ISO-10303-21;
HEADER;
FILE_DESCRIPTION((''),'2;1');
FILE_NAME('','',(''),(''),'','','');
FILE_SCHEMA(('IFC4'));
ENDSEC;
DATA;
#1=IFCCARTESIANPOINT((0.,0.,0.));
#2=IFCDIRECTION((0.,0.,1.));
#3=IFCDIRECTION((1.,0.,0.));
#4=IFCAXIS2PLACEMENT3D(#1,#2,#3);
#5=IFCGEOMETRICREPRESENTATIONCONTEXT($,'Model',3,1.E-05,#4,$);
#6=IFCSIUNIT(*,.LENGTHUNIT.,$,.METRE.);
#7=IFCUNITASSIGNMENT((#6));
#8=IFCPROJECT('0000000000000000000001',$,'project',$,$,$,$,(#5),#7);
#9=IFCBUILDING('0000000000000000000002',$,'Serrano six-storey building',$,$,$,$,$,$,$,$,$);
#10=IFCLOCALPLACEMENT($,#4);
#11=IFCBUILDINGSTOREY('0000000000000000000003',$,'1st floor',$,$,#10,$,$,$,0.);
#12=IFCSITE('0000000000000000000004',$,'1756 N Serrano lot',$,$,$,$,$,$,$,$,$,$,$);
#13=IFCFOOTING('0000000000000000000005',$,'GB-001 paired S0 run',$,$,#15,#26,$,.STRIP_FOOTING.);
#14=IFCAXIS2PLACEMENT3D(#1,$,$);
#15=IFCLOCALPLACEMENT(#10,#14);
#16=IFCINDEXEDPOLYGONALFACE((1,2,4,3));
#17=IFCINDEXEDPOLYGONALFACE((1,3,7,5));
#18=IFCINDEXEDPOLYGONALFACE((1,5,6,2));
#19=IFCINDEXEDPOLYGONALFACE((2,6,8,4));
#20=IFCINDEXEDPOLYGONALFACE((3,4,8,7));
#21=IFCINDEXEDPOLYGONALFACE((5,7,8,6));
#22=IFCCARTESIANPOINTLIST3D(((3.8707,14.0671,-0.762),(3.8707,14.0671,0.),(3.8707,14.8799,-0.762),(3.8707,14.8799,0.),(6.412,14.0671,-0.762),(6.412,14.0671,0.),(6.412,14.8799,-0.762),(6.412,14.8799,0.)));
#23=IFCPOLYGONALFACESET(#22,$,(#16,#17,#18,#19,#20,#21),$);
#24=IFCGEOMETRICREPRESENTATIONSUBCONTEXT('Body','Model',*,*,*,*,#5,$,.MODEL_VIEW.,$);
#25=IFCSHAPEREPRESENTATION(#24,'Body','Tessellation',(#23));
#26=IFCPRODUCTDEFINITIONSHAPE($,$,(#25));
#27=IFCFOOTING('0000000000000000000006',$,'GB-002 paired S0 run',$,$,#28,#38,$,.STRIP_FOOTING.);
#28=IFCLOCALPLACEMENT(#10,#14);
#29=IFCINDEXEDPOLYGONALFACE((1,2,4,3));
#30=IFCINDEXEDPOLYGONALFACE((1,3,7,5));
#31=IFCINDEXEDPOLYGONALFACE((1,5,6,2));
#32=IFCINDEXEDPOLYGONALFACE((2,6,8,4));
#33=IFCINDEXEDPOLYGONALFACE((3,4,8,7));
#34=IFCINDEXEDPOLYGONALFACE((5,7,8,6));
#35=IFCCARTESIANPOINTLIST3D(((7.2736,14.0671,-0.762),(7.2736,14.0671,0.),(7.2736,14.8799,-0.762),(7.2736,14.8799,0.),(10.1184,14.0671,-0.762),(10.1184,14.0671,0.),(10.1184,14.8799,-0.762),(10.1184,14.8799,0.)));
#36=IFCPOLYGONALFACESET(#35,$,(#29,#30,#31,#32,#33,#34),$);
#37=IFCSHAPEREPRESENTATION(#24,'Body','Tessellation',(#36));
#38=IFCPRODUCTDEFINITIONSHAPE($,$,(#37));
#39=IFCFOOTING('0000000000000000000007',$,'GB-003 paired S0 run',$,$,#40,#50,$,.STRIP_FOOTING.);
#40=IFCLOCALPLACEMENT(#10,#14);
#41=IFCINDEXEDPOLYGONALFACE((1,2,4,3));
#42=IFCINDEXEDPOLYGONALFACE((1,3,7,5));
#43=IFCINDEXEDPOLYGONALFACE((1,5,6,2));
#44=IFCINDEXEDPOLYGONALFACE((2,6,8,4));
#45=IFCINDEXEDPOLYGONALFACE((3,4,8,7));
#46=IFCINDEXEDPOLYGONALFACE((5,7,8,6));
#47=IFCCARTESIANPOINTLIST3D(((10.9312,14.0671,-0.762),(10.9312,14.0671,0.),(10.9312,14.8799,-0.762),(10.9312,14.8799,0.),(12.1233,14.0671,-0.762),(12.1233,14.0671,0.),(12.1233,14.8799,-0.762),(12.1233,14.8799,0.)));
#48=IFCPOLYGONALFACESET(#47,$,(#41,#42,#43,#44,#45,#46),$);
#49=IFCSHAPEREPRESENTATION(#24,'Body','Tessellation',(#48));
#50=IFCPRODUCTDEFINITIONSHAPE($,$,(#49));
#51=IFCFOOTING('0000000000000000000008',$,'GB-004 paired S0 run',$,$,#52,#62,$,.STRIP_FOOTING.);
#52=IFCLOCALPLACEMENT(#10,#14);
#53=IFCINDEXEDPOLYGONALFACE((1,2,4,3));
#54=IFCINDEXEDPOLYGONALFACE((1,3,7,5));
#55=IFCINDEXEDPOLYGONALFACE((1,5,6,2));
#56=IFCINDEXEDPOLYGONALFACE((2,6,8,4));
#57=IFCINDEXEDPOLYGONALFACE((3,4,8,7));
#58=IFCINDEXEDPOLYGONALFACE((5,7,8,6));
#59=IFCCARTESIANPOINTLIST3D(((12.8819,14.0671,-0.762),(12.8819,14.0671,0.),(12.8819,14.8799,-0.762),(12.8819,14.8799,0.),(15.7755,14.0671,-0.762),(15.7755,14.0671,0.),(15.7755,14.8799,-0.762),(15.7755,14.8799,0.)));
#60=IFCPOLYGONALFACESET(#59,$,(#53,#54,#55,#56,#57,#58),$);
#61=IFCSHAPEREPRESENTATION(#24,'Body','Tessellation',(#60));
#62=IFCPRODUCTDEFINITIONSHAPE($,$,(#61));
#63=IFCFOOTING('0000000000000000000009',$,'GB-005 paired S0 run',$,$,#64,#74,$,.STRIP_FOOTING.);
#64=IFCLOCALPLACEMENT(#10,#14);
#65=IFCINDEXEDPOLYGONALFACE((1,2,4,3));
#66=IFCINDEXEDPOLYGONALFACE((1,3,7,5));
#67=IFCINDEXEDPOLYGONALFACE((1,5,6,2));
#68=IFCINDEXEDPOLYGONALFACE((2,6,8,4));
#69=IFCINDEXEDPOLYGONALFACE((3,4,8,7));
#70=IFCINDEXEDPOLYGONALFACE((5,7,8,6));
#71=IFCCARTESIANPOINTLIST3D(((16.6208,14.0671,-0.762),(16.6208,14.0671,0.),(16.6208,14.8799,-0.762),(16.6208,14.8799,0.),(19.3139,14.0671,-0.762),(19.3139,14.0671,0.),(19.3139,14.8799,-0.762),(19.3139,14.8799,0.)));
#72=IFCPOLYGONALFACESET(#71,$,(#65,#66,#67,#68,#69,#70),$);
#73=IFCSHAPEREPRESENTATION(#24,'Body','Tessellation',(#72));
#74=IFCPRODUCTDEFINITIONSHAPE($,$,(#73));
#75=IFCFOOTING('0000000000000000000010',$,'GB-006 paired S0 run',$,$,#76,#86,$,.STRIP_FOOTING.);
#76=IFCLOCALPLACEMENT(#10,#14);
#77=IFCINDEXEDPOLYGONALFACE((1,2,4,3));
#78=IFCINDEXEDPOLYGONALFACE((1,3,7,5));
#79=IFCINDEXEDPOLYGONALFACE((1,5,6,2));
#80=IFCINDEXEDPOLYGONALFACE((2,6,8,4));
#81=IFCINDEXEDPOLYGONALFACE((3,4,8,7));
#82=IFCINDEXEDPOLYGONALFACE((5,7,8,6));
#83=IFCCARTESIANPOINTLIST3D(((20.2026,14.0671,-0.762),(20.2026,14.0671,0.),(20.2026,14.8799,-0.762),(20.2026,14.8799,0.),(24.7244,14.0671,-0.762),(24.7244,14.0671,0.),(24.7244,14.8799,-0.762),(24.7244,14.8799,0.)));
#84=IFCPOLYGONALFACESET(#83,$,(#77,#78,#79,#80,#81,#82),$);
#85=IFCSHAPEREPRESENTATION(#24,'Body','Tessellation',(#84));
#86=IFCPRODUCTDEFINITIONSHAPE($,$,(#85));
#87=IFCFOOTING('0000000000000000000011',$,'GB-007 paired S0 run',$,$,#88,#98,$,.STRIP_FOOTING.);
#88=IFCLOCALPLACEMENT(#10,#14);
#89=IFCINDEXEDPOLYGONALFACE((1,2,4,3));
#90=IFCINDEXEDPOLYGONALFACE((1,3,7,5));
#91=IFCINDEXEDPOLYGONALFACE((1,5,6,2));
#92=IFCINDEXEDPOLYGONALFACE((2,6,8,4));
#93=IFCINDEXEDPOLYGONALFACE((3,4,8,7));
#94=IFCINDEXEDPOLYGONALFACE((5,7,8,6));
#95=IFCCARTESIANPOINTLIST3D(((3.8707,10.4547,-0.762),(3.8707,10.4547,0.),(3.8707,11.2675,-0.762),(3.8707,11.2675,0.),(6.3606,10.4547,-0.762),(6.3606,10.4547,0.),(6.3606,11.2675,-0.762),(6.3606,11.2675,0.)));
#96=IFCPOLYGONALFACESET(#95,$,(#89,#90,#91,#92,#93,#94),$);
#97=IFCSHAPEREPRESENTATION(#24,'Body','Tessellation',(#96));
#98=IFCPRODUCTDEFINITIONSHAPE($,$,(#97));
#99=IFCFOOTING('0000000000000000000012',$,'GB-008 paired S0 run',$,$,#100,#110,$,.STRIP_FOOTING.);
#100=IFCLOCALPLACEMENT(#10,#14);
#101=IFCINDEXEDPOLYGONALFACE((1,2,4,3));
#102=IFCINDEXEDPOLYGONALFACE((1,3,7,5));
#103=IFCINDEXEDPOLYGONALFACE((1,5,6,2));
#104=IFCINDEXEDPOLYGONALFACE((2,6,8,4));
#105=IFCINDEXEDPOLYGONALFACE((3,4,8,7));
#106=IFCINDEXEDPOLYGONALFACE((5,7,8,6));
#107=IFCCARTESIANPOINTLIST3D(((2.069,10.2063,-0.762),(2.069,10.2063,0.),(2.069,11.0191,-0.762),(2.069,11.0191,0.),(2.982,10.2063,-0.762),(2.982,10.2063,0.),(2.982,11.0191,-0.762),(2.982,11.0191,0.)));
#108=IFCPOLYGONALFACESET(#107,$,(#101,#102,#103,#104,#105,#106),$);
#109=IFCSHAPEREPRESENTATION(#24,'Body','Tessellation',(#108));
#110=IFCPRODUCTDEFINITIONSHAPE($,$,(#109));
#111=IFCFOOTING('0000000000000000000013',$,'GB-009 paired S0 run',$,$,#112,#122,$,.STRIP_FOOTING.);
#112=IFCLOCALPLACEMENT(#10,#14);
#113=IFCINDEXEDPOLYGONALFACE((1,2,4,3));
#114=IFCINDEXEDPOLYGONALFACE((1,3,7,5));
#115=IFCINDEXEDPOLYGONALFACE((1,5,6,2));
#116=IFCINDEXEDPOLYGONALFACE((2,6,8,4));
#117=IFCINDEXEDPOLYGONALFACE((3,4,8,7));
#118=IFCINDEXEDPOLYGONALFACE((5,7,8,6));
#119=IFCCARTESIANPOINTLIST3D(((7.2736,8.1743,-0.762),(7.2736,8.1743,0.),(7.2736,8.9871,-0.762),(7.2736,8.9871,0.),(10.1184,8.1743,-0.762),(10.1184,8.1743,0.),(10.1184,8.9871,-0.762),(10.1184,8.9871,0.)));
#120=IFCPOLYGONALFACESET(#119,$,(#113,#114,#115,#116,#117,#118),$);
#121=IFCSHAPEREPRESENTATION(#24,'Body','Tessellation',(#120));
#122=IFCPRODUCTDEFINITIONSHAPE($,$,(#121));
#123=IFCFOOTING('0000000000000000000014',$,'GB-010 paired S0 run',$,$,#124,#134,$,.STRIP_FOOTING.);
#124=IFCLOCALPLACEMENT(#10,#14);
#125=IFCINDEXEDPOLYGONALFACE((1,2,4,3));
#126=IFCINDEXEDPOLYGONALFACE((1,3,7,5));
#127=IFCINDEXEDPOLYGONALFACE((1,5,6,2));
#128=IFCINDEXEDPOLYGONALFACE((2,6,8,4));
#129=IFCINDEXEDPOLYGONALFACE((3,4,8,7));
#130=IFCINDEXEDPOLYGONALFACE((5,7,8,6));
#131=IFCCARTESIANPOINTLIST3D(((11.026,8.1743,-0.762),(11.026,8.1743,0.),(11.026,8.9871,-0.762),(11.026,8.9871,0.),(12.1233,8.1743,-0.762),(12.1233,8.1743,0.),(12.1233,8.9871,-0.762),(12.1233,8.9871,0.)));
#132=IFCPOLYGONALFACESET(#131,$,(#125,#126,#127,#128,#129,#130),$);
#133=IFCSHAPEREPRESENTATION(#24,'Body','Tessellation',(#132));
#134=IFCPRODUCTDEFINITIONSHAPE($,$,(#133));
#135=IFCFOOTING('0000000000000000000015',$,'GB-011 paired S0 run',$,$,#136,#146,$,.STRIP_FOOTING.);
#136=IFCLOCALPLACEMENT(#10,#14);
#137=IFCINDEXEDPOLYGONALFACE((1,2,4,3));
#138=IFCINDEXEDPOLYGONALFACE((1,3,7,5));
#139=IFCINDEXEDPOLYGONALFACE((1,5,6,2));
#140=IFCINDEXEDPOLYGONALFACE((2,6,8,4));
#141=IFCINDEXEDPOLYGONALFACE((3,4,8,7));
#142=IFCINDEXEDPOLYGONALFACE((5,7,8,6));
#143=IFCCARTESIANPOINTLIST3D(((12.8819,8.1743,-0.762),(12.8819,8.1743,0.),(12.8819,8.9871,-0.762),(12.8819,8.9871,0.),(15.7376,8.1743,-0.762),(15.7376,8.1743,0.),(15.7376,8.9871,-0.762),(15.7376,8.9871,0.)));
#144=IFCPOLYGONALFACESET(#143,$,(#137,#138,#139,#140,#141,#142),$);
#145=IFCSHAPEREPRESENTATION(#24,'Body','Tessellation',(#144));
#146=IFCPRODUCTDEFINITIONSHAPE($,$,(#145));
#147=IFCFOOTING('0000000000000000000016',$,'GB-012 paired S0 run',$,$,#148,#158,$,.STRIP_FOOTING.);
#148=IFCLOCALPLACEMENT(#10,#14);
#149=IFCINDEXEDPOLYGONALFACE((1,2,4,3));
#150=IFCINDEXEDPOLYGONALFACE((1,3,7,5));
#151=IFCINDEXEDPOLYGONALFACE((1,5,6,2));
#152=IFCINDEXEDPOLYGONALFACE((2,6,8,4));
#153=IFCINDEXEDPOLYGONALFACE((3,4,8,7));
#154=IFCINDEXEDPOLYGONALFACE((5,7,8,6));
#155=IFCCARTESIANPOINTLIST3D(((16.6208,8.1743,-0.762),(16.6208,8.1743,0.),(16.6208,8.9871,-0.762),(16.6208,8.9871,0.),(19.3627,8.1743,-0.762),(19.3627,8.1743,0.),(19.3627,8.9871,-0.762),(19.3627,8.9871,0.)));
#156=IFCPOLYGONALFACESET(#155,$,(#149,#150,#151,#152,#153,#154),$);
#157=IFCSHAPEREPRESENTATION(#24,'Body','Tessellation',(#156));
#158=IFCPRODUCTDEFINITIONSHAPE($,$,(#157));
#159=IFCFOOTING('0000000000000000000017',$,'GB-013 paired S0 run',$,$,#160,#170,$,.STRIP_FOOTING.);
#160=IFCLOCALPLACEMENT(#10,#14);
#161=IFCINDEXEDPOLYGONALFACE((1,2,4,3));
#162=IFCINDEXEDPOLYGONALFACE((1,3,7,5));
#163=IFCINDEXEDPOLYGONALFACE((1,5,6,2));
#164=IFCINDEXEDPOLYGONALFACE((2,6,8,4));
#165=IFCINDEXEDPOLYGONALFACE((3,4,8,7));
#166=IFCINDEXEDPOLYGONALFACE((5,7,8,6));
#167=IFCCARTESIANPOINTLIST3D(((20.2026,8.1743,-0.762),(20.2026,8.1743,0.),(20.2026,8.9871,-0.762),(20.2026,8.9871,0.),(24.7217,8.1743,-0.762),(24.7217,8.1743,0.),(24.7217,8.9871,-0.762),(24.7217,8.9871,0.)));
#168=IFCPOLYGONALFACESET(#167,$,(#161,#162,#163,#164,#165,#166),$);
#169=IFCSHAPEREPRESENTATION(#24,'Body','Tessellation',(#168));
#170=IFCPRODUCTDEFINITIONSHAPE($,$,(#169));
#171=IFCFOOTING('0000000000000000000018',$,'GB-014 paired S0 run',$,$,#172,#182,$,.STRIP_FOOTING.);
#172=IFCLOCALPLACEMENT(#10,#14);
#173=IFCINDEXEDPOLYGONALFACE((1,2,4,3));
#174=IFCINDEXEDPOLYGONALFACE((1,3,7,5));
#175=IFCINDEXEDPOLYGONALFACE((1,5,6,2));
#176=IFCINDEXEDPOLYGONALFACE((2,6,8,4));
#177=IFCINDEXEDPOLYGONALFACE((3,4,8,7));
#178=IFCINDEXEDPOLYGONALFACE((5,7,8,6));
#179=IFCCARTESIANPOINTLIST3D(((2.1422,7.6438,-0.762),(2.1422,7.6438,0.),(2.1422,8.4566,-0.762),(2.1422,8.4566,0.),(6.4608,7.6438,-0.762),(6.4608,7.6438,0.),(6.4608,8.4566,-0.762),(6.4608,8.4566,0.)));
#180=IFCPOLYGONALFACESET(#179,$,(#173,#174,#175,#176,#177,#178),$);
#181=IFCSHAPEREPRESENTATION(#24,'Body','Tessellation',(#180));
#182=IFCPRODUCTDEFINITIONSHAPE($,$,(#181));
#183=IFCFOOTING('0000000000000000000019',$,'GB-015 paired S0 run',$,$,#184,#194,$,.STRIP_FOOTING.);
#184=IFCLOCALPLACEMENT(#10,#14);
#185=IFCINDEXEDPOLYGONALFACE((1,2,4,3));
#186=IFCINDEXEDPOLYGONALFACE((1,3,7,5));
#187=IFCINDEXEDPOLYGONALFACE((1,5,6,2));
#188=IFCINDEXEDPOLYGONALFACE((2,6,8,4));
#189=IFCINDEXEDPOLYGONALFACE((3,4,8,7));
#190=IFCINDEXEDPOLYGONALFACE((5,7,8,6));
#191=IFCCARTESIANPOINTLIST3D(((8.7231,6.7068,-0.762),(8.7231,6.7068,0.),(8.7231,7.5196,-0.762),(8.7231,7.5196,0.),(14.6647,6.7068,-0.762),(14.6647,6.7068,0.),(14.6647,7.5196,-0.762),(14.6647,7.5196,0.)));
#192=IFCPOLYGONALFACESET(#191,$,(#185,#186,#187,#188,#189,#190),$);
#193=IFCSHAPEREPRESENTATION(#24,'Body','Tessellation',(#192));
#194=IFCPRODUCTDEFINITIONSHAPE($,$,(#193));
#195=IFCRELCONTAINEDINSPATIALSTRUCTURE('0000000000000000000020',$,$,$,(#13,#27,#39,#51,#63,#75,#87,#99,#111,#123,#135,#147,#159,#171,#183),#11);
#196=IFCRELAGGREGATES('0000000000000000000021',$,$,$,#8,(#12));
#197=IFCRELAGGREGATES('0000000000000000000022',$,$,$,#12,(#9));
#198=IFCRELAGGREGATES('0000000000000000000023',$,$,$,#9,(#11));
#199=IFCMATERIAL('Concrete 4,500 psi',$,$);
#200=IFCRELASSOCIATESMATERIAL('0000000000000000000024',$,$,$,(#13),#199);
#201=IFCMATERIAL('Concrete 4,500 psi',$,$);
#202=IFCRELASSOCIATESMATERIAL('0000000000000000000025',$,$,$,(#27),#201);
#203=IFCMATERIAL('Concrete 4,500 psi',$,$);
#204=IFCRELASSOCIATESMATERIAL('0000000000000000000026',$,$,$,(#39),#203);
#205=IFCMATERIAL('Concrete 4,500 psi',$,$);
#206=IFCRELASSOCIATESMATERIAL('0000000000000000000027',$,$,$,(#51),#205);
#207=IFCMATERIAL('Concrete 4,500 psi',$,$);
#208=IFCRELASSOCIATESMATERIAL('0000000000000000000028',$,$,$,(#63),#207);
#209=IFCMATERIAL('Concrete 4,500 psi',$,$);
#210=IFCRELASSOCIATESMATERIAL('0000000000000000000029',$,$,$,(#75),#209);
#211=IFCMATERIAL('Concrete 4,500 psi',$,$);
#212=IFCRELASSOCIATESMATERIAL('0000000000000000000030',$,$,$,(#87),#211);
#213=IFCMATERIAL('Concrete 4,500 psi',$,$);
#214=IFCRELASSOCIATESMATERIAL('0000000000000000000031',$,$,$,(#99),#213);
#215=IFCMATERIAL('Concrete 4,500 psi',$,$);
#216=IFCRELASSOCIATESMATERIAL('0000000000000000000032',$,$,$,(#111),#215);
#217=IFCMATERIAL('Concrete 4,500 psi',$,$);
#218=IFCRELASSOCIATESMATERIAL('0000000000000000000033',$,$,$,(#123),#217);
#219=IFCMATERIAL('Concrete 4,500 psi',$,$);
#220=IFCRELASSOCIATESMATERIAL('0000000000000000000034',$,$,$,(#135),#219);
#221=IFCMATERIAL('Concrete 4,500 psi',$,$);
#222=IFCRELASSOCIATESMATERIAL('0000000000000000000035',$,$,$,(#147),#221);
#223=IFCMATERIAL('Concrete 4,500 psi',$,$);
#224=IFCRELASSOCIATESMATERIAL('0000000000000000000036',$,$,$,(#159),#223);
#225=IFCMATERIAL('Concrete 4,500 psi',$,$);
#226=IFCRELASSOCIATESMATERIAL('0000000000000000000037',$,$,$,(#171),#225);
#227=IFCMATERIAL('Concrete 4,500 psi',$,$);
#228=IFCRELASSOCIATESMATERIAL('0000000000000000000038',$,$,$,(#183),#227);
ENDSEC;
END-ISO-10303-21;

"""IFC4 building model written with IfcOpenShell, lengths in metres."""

from ifc_helpers import new_model, si_unit, frame, origin_with_axes, place, context, subcontext, project, spatial, polyline, outline, extrude, material, element, save


model = new_model("IFC4")

# Units and contexts
model_context = context("Model", 3, precision=1e-05, world=origin_with_axes())
body_context = subcontext(model_context, "Body", "Model", "MODEL_VIEW")
ifc_project = project(units=[si_unit("LENGTHUNIT", "METRE")], contexts=[model_context])

# Site, building, storey
site = spatial("IfcSite", under=ifc_project, Name="1756 N Serrano lot")
building = spatial("IfcBuilding", under=site, Name="Serrano six-storey building")
storey_placement = place(None, origin_with_axes())
storey = spatial("IfcBuildingStorey", under=building, at=storey_placement, Name="1st floor", Elevation=0.0)

# Footings
ifc_material_1 = material(Name="Concrete 4,500 psi")
footing_1_placement = place(storey_placement, origin_with_axes())
element("IfcFooting", 1, at=footing_1_placement, inside=storey, material=ifc_material_1, Name="GB-001 paired S0 run", PredefinedType="STRIP_FOOTING", context=body_context, shape_type="SweptSolid", body=[
    extrude(outline(polyline([(6.412, 14.8799), (6.412, 14.0671), (3.8707, 14.0671), (3.8707, 14.8799), (6.412, 14.8799)])), frame((0.0, 0.0, -0.762)), (0.0, 0.0, 1.0), 0.762),
])
ifc_material_2 = material(Name="Concrete 4,500 psi")
footing_2_placement = place(storey_placement, origin_with_axes())
element("IfcFooting", 2, at=footing_2_placement, inside=storey, material=ifc_material_2, Name="GB-002 paired S0 run", PredefinedType="STRIP_FOOTING", context=body_context, shape_type="SweptSolid", body=[
    extrude(outline(polyline([(10.1184, 14.8799), (10.1184, 14.0671), (7.2736, 14.0671), (7.2736, 14.8799), (10.1184, 14.8799)])), frame((0.0, 0.0, -0.762)), (0.0, 0.0, 1.0), 0.762),
])
ifc_material_3 = material(Name="Concrete 4,500 psi")
footing_3_placement = place(storey_placement, origin_with_axes())
element("IfcFooting", 3, at=footing_3_placement, inside=storey, material=ifc_material_3, Name="GB-003 paired S0 run", PredefinedType="STRIP_FOOTING", context=body_context, shape_type="SweptSolid", body=[
    extrude(outline(polyline([(12.1233, 14.8799), (12.1233, 14.0671), (10.9312, 14.0671), (10.9312, 14.8799), (12.1233, 14.8799)])), frame((0.0, 0.0, -0.762)), (0.0, 0.0, 1.0), 0.762),
])
ifc_material_4 = material(Name="Concrete 4,500 psi")
footing_4_placement = place(storey_placement, origin_with_axes())
element("IfcFooting", 4, at=footing_4_placement, inside=storey, material=ifc_material_4, Name="GB-004 paired S0 run", PredefinedType="STRIP_FOOTING", context=body_context, shape_type="SweptSolid", body=[
    extrude(outline(polyline([(15.7755, 14.8799), (15.7755, 14.0671), (12.8819, 14.0671), (12.8819, 14.8799), (15.7755, 14.8799)])), frame((0.0, 0.0, -0.762)), (0.0, 0.0, 1.0), 0.762),
])
ifc_material_5 = material(Name="Concrete 4,500 psi")
footing_5_placement = place(storey_placement, origin_with_axes())
element("IfcFooting", 5, at=footing_5_placement, inside=storey, material=ifc_material_5, Name="GB-005 paired S0 run", PredefinedType="STRIP_FOOTING", context=body_context, shape_type="SweptSolid", body=[
    extrude(outline(polyline([(19.3139, 14.8799), (19.3139, 14.0671), (16.6208, 14.0671), (16.6208, 14.8799), (19.3139, 14.8799)])), frame((0.0, 0.0, -0.762)), (0.0, 0.0, 1.0), 0.762),
])
ifc_material_6 = material(Name="Concrete 4,500 psi")
footing_6_placement = place(storey_placement, origin_with_axes())
element("IfcFooting", 6, at=footing_6_placement, inside=storey, material=ifc_material_6, Name="GB-006 paired S0 run", PredefinedType="STRIP_FOOTING", context=body_context, shape_type="SweptSolid", body=[
    extrude(outline(polyline([(24.7244, 14.8799), (24.7244, 14.0671), (20.2026, 14.0671), (20.2026, 14.8799), (24.7244, 14.8799)])), frame((0.0, 0.0, -0.762)), (0.0, 0.0, 1.0), 0.762),
])
ifc_material_7 = material(Name="Concrete 4,500 psi")
footing_7_placement = place(storey_placement, origin_with_axes())
element("IfcFooting", 7, at=footing_7_placement, inside=storey, material=ifc_material_7, Name="GB-007 paired S0 run", PredefinedType="STRIP_FOOTING", context=body_context, shape_type="SweptSolid", body=[
    extrude(outline(polyline([(6.3606, 11.2675), (6.3606, 10.4547), (3.8707, 10.4547), (3.8707, 11.2675), (6.3606, 11.2675)])), frame((0.0, 0.0, -0.762)), (0.0, 0.0, 1.0), 0.762),
])
ifc_material_8 = material(Name="Concrete 4,500 psi")
footing_8_placement = place(storey_placement, origin_with_axes())
element("IfcFooting", 8, at=footing_8_placement, inside=storey, material=ifc_material_8, Name="GB-008 paired S0 run", PredefinedType="STRIP_FOOTING", context=body_context, shape_type="SweptSolid", body=[
    extrude(outline(polyline([(2.982, 11.0191), (2.982, 10.2063), (2.069, 10.2063), (2.069, 11.0191), (2.982, 11.0191)])), frame((0.0, 0.0, -0.762)), (0.0, 0.0, 1.0), 0.762),
])
ifc_material_9 = material(Name="Concrete 4,500 psi")
footing_9_placement = place(storey_placement, origin_with_axes())
element("IfcFooting", 9, at=footing_9_placement, inside=storey, material=ifc_material_9, Name="GB-009 paired S0 run", PredefinedType="STRIP_FOOTING", context=body_context, shape_type="SweptSolid", body=[
    extrude(outline(polyline([(10.1184, 8.9871), (10.1184, 8.1743), (7.2736, 8.1743), (7.2736, 8.9871), (10.1184, 8.9871)])), frame((0.0, 0.0, -0.762)), (0.0, 0.0, 1.0), 0.762),
])
ifc_material_10 = material(Name="Concrete 4,500 psi")
footing_10_placement = place(storey_placement, origin_with_axes())
element("IfcFooting", 10, at=footing_10_placement, inside=storey, material=ifc_material_10, Name="GB-010 paired S0 run", PredefinedType="STRIP_FOOTING", context=body_context, shape_type="SweptSolid", body=[
    extrude(outline(polyline([(12.1233, 8.9871), (12.1233, 8.1743), (11.026, 8.1743), (11.026, 8.9871), (12.1233, 8.9871)])), frame((0.0, 0.0, -0.762)), (0.0, 0.0, 1.0), 0.762),
])
ifc_material_11 = material(Name="Concrete 4,500 psi")
footing_11_placement = place(storey_placement, origin_with_axes())
element("IfcFooting", 11, at=footing_11_placement, inside=storey, material=ifc_material_11, Name="GB-011 paired S0 run", PredefinedType="STRIP_FOOTING", context=body_context, shape_type="SweptSolid", body=[
    extrude(outline(polyline([(15.7376, 8.9871), (15.7376, 8.1743), (12.8819, 8.1743), (12.8819, 8.9871), (15.7376, 8.9871)])), frame((0.0, 0.0, -0.762)), (0.0, 0.0, 1.0), 0.762),
])
ifc_material_12 = material(Name="Concrete 4,500 psi")
footing_12_placement = place(storey_placement, origin_with_axes())
element("IfcFooting", 12, at=footing_12_placement, inside=storey, material=ifc_material_12, Name="GB-012 paired S0 run", PredefinedType="STRIP_FOOTING", context=body_context, shape_type="SweptSolid", body=[
    extrude(outline(polyline([(19.3627, 8.9871), (19.3627, 8.1743), (16.6208, 8.1743), (16.6208, 8.9871), (19.3627, 8.9871)])), frame((0.0, 0.0, -0.762)), (0.0, 0.0, 1.0), 0.762),
])
ifc_material_13 = material(Name="Concrete 4,500 psi")
footing_13_placement = place(storey_placement, origin_with_axes())
element("IfcFooting", 13, at=footing_13_placement, inside=storey, material=ifc_material_13, Name="GB-013 paired S0 run", PredefinedType="STRIP_FOOTING", context=body_context, shape_type="SweptSolid", body=[
    extrude(outline(polyline([(24.7217, 8.9871), (24.7217, 8.1743), (20.2026, 8.1743), (20.2026, 8.9871), (24.7217, 8.9871)])), frame((0.0, 0.0, -0.762)), (0.0, 0.0, 1.0), 0.762),
])
ifc_material_14 = material(Name="Concrete 4,500 psi")
footing_14_placement = place(storey_placement, origin_with_axes())
element("IfcFooting", 14, at=footing_14_placement, inside=storey, material=ifc_material_14, Name="GB-014 paired S0 run", PredefinedType="STRIP_FOOTING", context=body_context, shape_type="SweptSolid", body=[
    extrude(outline(polyline([(6.4608, 8.4566), (6.4608, 7.6438), (2.1422, 7.6438), (2.1422, 8.4566), (6.4608, 8.4566)])), frame((0.0, 0.0, -0.762)), (0.0, 0.0, 1.0), 0.762),
])
ifc_material_15 = material(Name="Concrete 4,500 psi")
footing_15_placement = place(storey_placement, origin_with_axes())
element("IfcFooting", 15, at=footing_15_placement, inside=storey, material=ifc_material_15, Name="GB-015 paired S0 run", PredefinedType="STRIP_FOOTING", context=body_context, shape_type="SweptSolid", body=[
    extrude(outline(polyline([(14.6647, 7.5196), (14.6647, 6.7068), (8.7231, 6.7068), (8.7231, 7.5196), (14.6647, 7.5196)])), frame((0.0, 0.0, -0.762)), (0.0, 0.0, 1.0), 0.762),
])

save(model, "model.ifc")
